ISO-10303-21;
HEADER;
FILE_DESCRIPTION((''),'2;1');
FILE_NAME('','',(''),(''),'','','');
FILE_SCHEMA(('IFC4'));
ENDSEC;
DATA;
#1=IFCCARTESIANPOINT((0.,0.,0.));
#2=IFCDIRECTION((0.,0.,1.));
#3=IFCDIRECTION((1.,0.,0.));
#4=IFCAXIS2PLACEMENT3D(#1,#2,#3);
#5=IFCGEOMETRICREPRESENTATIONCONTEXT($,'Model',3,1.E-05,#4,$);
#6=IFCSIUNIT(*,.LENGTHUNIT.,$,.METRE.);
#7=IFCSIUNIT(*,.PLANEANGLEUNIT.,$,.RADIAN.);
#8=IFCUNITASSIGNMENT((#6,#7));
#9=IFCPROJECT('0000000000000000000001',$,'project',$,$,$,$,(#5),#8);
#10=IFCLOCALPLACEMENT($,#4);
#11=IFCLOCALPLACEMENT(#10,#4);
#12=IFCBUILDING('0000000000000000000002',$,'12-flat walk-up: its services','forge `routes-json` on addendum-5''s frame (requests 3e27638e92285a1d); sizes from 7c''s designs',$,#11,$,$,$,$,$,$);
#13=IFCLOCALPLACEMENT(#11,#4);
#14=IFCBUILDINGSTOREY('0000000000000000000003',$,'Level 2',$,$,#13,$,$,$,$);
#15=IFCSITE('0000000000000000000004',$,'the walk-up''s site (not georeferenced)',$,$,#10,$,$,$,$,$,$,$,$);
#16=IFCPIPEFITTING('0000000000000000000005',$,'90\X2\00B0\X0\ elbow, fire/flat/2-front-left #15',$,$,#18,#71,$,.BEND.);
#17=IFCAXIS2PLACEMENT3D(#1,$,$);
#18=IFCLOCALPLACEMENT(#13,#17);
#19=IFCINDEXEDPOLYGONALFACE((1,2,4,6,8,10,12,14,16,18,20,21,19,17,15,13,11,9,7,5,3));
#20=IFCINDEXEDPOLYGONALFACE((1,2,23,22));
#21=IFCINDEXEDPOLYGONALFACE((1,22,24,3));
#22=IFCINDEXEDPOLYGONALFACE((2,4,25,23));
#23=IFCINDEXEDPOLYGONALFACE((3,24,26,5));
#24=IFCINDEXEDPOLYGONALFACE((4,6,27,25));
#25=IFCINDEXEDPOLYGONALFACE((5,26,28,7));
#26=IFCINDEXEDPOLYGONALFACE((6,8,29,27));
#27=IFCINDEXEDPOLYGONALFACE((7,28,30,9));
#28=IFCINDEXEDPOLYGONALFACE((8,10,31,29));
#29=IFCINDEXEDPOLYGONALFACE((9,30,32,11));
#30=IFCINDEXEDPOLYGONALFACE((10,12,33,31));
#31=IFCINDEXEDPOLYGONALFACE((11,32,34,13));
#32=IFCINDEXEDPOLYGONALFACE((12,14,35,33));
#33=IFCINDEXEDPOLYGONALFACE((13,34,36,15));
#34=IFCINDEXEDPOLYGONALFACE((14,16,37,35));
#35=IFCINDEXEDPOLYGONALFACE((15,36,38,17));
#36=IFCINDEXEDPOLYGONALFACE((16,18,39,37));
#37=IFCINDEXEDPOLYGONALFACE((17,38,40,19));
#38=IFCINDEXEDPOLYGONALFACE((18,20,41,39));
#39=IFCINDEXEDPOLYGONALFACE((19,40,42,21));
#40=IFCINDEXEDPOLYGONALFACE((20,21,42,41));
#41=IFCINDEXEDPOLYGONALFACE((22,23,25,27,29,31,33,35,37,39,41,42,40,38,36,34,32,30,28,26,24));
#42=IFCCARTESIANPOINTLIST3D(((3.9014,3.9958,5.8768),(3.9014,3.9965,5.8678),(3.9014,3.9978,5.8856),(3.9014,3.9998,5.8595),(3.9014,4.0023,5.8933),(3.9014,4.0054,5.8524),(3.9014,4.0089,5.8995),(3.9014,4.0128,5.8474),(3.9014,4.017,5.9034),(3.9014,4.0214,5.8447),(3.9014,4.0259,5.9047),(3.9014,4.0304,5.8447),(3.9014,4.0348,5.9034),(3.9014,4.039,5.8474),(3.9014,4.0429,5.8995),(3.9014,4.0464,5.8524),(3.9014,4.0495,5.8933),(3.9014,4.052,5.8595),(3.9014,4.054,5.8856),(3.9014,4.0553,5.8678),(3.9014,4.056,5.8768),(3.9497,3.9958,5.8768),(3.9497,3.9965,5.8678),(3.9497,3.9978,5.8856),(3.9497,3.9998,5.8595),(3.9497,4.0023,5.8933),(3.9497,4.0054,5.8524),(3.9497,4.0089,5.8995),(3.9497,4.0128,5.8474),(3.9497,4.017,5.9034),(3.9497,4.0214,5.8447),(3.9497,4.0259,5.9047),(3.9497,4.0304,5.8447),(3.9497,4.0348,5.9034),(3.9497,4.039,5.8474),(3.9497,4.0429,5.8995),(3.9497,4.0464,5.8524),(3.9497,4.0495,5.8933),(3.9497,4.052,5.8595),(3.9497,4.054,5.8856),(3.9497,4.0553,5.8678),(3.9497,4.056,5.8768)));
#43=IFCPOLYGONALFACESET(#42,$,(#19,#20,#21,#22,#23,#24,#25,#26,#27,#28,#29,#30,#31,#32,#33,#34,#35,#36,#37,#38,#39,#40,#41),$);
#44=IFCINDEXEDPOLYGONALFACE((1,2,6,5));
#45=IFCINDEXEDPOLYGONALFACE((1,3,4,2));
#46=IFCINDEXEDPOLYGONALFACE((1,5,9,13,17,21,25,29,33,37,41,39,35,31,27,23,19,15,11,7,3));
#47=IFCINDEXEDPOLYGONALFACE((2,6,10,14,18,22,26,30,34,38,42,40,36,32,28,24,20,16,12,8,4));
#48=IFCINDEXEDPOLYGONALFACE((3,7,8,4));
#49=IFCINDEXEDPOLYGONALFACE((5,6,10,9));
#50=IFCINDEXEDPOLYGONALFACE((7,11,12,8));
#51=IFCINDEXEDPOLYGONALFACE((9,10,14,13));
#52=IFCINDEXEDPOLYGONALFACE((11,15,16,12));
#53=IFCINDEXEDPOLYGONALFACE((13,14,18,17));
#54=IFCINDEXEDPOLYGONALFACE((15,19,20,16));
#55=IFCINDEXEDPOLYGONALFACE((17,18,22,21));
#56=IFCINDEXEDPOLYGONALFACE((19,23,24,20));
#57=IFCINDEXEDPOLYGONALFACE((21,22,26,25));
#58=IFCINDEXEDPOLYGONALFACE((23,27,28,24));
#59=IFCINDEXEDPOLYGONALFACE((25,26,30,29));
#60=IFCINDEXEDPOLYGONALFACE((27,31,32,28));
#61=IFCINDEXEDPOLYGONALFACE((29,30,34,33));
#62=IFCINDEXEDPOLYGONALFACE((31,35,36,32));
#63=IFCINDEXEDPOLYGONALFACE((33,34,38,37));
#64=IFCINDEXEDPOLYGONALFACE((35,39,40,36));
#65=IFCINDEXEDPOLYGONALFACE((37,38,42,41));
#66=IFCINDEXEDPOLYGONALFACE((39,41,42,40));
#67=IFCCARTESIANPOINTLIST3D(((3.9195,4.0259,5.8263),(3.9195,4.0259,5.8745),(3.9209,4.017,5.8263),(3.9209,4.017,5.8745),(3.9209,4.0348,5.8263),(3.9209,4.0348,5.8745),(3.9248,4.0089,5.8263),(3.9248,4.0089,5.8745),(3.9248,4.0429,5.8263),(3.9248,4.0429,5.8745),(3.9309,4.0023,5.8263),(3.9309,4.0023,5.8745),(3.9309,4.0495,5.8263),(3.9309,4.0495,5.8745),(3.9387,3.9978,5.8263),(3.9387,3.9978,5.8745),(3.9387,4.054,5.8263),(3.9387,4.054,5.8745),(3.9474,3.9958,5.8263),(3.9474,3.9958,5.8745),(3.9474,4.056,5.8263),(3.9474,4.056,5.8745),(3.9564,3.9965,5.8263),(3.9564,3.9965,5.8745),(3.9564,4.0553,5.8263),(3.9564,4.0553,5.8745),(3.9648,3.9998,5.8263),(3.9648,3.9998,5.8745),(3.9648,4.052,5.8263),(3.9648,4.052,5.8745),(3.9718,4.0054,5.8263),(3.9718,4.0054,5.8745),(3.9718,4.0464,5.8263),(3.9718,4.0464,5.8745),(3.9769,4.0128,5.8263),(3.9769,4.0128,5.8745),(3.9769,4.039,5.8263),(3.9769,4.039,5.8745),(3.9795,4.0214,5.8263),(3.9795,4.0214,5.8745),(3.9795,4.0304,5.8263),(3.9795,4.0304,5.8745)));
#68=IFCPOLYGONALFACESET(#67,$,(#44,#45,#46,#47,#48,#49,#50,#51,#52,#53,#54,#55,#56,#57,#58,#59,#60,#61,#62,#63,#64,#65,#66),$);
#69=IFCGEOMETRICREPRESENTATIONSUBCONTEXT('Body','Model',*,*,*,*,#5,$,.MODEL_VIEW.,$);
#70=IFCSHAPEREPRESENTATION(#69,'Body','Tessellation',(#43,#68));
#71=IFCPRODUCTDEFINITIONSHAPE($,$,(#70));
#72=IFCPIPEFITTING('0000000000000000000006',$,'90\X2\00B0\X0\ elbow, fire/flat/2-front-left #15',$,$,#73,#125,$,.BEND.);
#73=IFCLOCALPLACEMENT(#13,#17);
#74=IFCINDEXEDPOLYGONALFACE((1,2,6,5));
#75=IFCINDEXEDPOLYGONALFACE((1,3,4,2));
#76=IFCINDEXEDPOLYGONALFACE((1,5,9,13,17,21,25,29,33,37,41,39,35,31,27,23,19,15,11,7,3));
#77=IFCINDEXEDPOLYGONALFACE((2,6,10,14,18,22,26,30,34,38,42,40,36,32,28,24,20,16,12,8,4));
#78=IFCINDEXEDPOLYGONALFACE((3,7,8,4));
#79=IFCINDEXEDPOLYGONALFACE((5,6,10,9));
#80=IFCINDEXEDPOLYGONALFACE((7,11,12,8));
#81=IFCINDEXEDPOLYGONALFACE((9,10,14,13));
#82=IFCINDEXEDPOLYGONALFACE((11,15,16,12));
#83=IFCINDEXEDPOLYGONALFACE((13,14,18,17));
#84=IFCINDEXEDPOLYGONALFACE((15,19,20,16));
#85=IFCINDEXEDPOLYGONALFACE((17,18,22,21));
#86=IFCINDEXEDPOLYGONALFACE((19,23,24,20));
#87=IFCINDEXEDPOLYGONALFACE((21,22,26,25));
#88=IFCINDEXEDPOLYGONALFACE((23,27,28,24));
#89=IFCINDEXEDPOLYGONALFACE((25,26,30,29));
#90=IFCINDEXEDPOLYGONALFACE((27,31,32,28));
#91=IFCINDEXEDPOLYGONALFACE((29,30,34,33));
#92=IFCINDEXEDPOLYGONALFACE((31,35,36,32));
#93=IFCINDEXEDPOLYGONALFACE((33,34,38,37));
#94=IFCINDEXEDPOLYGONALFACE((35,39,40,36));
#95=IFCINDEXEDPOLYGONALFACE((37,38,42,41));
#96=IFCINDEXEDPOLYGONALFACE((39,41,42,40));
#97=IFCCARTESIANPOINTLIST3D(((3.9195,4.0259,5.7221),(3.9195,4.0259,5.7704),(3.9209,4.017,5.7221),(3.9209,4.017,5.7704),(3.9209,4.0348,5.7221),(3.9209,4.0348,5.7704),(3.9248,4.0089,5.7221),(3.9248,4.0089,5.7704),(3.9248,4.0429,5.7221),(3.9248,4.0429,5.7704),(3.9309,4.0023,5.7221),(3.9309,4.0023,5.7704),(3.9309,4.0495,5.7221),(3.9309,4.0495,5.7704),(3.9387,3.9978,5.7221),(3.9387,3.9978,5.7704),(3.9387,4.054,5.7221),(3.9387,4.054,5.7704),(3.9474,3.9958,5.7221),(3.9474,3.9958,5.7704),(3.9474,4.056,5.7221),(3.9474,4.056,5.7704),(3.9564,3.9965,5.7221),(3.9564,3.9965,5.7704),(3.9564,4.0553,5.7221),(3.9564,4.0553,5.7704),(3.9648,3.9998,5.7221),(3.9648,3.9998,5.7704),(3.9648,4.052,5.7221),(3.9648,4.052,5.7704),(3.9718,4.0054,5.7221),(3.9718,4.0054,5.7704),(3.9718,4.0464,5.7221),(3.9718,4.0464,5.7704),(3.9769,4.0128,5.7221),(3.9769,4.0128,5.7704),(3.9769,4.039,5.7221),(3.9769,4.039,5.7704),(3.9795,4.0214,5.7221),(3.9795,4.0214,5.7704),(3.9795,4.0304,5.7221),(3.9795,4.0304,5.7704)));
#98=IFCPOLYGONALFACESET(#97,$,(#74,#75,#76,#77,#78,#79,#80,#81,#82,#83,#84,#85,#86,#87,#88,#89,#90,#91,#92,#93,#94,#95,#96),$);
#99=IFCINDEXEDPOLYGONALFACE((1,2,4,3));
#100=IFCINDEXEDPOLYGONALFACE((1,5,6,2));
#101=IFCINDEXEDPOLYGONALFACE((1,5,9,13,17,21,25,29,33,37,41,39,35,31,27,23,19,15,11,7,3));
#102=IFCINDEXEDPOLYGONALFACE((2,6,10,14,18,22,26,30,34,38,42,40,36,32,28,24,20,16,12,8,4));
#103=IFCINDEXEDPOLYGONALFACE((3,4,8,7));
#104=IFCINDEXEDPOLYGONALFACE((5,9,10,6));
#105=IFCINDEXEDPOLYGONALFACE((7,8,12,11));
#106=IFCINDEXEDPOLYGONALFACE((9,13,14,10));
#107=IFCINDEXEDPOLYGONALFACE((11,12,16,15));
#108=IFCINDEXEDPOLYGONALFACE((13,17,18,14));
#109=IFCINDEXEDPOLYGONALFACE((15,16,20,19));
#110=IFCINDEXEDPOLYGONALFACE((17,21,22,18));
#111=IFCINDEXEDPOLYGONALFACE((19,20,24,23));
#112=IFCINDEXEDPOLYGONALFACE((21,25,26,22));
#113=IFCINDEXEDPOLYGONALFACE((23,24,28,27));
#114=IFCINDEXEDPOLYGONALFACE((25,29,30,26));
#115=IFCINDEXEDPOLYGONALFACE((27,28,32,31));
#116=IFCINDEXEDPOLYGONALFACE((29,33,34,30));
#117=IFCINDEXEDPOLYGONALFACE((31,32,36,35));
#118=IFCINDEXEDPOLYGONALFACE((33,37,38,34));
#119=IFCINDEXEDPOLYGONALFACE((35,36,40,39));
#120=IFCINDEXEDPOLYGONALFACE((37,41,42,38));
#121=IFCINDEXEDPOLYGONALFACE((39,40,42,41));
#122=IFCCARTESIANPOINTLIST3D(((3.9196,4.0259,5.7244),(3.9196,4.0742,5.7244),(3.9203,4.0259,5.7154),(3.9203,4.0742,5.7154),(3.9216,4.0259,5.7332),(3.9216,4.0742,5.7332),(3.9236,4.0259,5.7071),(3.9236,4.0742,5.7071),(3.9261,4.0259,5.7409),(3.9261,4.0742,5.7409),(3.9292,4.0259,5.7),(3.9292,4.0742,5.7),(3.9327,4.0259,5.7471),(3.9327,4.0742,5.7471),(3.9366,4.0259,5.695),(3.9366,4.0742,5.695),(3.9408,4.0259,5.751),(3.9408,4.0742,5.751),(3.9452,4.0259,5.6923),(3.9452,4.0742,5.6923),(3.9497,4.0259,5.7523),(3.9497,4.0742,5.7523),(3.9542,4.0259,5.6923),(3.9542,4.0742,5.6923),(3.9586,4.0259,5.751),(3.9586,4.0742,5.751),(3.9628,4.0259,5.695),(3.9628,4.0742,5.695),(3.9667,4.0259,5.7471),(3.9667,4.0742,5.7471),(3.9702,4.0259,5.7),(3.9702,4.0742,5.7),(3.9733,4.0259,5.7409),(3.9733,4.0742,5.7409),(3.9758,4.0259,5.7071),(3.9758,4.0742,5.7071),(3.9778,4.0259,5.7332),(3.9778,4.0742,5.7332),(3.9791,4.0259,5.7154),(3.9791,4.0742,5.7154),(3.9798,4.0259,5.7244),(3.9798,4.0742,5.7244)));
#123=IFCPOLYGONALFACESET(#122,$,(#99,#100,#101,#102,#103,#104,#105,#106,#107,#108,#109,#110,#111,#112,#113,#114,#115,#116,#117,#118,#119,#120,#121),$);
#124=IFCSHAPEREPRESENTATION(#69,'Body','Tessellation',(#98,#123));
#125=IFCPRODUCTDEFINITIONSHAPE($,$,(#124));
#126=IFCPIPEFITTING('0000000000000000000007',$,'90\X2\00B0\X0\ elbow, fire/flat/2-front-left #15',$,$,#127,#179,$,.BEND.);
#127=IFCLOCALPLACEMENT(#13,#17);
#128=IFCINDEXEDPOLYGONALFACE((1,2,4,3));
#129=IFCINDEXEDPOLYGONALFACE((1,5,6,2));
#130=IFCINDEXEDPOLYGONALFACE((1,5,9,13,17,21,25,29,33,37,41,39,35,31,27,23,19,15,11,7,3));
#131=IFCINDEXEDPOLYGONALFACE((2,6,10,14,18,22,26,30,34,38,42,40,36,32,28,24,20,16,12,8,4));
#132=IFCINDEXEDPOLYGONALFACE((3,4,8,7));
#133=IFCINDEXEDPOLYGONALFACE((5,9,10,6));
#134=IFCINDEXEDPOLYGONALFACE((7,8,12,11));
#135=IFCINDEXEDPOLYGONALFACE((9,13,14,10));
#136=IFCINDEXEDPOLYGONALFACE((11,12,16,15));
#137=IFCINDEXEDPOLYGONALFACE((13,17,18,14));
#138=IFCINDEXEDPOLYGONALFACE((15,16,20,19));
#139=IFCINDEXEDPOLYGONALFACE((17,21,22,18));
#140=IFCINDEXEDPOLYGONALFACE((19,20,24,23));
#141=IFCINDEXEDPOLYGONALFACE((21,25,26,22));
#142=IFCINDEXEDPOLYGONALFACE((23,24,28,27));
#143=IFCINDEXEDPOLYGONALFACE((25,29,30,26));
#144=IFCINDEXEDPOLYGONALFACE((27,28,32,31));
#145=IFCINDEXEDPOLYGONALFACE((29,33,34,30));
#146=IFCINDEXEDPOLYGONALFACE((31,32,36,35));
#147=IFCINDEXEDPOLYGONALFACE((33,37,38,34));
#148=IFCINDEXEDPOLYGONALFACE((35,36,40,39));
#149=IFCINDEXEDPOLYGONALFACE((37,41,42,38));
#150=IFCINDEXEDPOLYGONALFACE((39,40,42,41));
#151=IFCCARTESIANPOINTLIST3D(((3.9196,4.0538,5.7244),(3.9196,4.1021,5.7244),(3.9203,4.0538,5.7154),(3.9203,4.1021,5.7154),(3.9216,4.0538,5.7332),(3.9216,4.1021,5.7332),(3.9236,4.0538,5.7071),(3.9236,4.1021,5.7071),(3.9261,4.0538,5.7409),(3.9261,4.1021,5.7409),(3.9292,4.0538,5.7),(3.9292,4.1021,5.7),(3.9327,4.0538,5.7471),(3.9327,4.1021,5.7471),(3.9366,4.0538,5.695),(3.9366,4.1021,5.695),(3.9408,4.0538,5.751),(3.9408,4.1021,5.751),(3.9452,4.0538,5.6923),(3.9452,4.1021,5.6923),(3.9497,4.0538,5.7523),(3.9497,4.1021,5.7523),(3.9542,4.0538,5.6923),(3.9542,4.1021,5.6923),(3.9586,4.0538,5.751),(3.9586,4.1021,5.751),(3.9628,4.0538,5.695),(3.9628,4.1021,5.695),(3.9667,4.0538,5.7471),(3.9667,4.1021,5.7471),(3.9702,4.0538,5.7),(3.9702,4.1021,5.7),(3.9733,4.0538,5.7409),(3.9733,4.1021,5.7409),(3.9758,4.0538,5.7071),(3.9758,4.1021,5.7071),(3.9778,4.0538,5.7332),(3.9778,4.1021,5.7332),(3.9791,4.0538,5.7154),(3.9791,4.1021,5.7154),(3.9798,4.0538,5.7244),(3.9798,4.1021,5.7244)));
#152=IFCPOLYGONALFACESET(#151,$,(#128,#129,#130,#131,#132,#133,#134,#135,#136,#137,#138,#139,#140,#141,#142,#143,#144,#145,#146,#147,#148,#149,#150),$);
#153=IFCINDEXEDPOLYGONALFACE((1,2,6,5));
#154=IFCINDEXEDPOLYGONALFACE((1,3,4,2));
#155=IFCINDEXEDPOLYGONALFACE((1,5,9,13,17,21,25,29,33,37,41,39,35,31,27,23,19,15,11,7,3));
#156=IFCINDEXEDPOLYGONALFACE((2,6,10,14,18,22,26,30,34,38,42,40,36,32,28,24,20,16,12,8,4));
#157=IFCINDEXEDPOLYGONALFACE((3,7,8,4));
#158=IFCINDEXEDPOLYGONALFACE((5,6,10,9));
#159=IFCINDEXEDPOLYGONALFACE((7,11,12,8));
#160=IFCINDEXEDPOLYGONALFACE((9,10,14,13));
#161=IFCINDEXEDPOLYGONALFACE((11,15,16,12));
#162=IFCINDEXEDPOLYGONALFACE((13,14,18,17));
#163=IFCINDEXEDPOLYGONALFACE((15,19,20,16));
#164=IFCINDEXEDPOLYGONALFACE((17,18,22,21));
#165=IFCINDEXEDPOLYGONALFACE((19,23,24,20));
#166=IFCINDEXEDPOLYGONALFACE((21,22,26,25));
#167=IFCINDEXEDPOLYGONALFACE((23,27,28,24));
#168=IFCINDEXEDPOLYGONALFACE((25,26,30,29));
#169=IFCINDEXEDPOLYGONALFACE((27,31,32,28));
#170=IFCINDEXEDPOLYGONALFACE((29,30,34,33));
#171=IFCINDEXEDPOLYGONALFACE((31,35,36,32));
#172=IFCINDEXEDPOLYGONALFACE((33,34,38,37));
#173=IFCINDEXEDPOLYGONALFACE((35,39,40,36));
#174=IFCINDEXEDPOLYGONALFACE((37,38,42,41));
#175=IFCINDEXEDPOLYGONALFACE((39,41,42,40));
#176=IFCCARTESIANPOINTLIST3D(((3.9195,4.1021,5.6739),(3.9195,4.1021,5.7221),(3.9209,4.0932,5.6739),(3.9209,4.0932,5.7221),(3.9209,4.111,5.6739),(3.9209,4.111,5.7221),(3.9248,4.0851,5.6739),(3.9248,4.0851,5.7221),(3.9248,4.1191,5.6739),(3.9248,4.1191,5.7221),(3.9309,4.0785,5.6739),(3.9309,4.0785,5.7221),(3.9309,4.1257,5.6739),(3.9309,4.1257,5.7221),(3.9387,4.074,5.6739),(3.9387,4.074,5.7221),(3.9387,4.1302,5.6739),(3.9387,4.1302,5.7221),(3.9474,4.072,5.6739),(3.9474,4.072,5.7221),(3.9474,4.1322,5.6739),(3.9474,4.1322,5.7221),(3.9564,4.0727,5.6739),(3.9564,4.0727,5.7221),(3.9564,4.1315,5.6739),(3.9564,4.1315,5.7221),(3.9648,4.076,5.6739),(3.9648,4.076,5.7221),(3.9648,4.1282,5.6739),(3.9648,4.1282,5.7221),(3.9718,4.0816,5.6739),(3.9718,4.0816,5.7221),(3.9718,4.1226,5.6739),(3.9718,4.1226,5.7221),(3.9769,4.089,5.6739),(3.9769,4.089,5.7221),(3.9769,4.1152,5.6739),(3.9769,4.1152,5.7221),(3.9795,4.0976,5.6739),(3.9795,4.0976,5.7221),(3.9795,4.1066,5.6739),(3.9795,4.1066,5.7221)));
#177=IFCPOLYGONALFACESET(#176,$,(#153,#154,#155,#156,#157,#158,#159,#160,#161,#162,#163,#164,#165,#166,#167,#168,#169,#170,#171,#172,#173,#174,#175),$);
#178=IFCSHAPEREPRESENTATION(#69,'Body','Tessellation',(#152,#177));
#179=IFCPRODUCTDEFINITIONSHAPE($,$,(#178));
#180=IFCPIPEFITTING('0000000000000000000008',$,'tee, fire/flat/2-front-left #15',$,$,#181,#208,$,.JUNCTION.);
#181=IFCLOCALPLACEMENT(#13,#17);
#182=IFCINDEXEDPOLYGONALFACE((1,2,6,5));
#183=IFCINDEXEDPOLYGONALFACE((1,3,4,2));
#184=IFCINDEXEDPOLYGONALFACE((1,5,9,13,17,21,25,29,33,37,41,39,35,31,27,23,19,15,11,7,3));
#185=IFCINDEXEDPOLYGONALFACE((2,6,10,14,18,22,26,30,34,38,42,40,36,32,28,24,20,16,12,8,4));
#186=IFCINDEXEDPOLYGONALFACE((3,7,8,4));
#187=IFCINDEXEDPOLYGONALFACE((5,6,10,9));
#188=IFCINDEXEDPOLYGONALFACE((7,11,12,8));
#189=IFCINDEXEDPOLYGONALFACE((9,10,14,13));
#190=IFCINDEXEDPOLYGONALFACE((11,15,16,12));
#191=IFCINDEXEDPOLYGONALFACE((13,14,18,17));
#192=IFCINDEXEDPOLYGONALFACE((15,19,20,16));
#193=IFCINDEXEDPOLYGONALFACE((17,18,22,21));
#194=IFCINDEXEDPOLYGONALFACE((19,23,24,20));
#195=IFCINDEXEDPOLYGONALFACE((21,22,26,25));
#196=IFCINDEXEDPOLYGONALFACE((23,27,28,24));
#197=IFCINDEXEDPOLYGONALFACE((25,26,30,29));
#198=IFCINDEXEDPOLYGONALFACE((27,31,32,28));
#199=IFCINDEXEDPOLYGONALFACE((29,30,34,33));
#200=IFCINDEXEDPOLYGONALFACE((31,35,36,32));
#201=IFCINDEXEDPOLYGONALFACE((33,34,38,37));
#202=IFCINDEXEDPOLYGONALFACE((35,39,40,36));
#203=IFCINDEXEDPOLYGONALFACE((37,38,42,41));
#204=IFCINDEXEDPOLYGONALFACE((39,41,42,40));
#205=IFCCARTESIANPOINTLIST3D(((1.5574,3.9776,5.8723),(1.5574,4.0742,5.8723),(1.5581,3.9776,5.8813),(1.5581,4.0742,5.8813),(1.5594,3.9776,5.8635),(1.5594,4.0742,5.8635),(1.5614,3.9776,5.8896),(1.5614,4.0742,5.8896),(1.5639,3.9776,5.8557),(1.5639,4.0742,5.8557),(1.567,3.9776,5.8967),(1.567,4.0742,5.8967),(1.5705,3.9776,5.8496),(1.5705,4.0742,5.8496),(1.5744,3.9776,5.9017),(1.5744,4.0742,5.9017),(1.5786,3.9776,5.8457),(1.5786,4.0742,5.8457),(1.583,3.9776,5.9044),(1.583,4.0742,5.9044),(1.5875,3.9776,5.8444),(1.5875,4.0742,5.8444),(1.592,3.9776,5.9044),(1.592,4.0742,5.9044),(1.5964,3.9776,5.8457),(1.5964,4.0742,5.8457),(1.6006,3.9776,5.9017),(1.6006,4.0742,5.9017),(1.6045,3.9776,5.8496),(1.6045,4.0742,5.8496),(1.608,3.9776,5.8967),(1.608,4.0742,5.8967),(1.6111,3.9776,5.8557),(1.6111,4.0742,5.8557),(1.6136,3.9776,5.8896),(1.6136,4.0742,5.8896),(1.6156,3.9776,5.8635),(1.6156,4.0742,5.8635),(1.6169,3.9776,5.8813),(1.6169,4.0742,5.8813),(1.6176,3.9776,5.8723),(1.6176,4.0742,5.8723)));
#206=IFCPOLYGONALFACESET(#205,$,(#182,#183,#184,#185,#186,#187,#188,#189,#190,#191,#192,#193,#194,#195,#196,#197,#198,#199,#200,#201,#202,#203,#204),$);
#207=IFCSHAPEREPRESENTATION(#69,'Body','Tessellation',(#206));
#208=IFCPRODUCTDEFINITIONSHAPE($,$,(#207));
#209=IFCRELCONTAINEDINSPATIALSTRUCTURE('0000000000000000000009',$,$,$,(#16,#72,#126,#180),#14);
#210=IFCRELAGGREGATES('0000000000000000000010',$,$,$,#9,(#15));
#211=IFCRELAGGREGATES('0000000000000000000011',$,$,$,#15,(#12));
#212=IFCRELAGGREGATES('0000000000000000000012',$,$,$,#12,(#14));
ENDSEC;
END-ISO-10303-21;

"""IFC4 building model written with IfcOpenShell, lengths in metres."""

from ifc_helpers import new_model, entity, si_unit, frame, origin_with_axes, place, context, subcontext, project, spatial, element, save


model = new_model("IFC4")

# Units and contexts
model_context = context("Model", 3, precision=1e-05, world=origin_with_axes())
body_context = subcontext(model_context, "Body", "Model", "MODEL_VIEW")
ifc_project = project(units=[si_unit("LENGTHUNIT", "METRE"), si_unit("PLANEANGLEUNIT", "RADIAN")], contexts=[model_context])

# Site, building, storey
site_placement = place(None, origin_with_axes())
site = spatial("IfcSite", under=ifc_project, at=site_placement, Name="the walk-up's site (not georeferenced)")
building_placement = place(site_placement, origin_with_axes())
building = spatial("IfcBuilding", under=site, at=building_placement, Name="12-flat walk-up: its services", Description="forge `routes-json` on addendum-5's frame (requests 3e27638e92285a1d); sizes from 7c's designs")
storey_placement = place(building_placement, origin_with_axes())
storey = spatial("IfcBuildingStorey", under=building, at=storey_placement, Name="Level 2")

# Pipe fittings
pipe_fitting_1_placement = place(storey_placement, frame((3.9014, 4.0259, 5.8745), z_axis=(0.0, 0.0, 1.0), x_axis=(1.0, 0.0, 0.0)))
element("IfcPipeFitting", 1, at=pipe_fitting_1_placement, inside=storey, Name="90° elbow, fire/flat/2-front-left #15", PredefinedType="BEND", context=body_context, shape_type="AdvancedSweptSolid", body=[
    entity("IfcSweptDiskSolid", entity("IfcPolyline", [entity("IfcCartesianPoint", [0.0, 0.0, 0.0]), entity("IfcCartesianPoint", [0.0483, 0.0, 0.0])]), 0.0302),
    entity("IfcSweptDiskSolid", entity("IfcPolyline", [entity("IfcCartesianPoint", [0.0483, 0.0, 0.0]), entity("IfcCartesianPoint", [0.0483, 0.0, -0.0483])]), 0.0302),
])
pipe_fitting_2_placement = place(storey_placement, frame((3.9497, 4.0259, 5.7704), z_axis=(0.0, 0.0, 1.0), x_axis=(1.0, 0.0, 0.0)))
element("IfcPipeFitting", 2, at=pipe_fitting_2_placement, inside=storey, Name="90° elbow, fire/flat/2-front-left #15", PredefinedType="BEND", context=body_context, shape_type="AdvancedSweptSolid", body=[
    entity("IfcSweptDiskSolid", entity("IfcPolyline", [entity("IfcCartesianPoint", [0.0, 0.0, 0.0]), entity("IfcCartesianPoint", [0.0, 0.0, -0.0483])]), 0.0302),
    entity("IfcSweptDiskSolid", entity("IfcPolyline", [entity("IfcCartesianPoint", [0.0, 0.0, -0.0483]), entity("IfcCartesianPoint", [0.0, 0.0483, -0.0483])]), 0.0302),
])
pipe_fitting_3_placement = place(storey_placement, frame((3.9497, 4.0538, 5.7221), z_axis=(0.0, 0.0, 1.0), x_axis=(1.0, 0.0, 0.0)))
element("IfcPipeFitting", 3, at=pipe_fitting_3_placement, inside=storey, Name="90° elbow, fire/flat/2-front-left #15", PredefinedType="BEND", context=body_context, shape_type="AdvancedSweptSolid", body=[
    entity("IfcSweptDiskSolid", entity("IfcPolyline", [entity("IfcCartesianPoint", [0.0, 0.0, 0.0]), entity("IfcCartesianPoint", [0.0, 0.0483, 0.0])]), 0.0302),
    entity("IfcSweptDiskSolid", entity("IfcPolyline", [entity("IfcCartesianPoint", [0.0, 0.0483, 0.0]), entity("IfcCartesianPoint", [0.0, 0.0483, -0.0483])]), 0.0302),
])
pipe_fitting_4_placement = place(storey_placement, frame((1.5875, 4.0742, 5.8745), z_axis=(0.0, 0.0, 1.0), x_axis=(1.0, 0.0, 0.0)))
element("IfcPipeFitting", 4, at=pipe_fitting_4_placement, inside=storey, Name="tee, fire/flat/2-front-left #15", PredefinedType="JUNCTION", context=body_context, shape_type="AdvancedSweptSolid", body=[
    entity("IfcSweptDiskSolid", entity("IfcPolyline", [entity("IfcCartesianPoint", [0.0, 0.0, 0.0]), entity("IfcCartesianPoint", [0.0, -0.0965, 0.0])]), 0.0302),
])

save(model, "model.ifc")
